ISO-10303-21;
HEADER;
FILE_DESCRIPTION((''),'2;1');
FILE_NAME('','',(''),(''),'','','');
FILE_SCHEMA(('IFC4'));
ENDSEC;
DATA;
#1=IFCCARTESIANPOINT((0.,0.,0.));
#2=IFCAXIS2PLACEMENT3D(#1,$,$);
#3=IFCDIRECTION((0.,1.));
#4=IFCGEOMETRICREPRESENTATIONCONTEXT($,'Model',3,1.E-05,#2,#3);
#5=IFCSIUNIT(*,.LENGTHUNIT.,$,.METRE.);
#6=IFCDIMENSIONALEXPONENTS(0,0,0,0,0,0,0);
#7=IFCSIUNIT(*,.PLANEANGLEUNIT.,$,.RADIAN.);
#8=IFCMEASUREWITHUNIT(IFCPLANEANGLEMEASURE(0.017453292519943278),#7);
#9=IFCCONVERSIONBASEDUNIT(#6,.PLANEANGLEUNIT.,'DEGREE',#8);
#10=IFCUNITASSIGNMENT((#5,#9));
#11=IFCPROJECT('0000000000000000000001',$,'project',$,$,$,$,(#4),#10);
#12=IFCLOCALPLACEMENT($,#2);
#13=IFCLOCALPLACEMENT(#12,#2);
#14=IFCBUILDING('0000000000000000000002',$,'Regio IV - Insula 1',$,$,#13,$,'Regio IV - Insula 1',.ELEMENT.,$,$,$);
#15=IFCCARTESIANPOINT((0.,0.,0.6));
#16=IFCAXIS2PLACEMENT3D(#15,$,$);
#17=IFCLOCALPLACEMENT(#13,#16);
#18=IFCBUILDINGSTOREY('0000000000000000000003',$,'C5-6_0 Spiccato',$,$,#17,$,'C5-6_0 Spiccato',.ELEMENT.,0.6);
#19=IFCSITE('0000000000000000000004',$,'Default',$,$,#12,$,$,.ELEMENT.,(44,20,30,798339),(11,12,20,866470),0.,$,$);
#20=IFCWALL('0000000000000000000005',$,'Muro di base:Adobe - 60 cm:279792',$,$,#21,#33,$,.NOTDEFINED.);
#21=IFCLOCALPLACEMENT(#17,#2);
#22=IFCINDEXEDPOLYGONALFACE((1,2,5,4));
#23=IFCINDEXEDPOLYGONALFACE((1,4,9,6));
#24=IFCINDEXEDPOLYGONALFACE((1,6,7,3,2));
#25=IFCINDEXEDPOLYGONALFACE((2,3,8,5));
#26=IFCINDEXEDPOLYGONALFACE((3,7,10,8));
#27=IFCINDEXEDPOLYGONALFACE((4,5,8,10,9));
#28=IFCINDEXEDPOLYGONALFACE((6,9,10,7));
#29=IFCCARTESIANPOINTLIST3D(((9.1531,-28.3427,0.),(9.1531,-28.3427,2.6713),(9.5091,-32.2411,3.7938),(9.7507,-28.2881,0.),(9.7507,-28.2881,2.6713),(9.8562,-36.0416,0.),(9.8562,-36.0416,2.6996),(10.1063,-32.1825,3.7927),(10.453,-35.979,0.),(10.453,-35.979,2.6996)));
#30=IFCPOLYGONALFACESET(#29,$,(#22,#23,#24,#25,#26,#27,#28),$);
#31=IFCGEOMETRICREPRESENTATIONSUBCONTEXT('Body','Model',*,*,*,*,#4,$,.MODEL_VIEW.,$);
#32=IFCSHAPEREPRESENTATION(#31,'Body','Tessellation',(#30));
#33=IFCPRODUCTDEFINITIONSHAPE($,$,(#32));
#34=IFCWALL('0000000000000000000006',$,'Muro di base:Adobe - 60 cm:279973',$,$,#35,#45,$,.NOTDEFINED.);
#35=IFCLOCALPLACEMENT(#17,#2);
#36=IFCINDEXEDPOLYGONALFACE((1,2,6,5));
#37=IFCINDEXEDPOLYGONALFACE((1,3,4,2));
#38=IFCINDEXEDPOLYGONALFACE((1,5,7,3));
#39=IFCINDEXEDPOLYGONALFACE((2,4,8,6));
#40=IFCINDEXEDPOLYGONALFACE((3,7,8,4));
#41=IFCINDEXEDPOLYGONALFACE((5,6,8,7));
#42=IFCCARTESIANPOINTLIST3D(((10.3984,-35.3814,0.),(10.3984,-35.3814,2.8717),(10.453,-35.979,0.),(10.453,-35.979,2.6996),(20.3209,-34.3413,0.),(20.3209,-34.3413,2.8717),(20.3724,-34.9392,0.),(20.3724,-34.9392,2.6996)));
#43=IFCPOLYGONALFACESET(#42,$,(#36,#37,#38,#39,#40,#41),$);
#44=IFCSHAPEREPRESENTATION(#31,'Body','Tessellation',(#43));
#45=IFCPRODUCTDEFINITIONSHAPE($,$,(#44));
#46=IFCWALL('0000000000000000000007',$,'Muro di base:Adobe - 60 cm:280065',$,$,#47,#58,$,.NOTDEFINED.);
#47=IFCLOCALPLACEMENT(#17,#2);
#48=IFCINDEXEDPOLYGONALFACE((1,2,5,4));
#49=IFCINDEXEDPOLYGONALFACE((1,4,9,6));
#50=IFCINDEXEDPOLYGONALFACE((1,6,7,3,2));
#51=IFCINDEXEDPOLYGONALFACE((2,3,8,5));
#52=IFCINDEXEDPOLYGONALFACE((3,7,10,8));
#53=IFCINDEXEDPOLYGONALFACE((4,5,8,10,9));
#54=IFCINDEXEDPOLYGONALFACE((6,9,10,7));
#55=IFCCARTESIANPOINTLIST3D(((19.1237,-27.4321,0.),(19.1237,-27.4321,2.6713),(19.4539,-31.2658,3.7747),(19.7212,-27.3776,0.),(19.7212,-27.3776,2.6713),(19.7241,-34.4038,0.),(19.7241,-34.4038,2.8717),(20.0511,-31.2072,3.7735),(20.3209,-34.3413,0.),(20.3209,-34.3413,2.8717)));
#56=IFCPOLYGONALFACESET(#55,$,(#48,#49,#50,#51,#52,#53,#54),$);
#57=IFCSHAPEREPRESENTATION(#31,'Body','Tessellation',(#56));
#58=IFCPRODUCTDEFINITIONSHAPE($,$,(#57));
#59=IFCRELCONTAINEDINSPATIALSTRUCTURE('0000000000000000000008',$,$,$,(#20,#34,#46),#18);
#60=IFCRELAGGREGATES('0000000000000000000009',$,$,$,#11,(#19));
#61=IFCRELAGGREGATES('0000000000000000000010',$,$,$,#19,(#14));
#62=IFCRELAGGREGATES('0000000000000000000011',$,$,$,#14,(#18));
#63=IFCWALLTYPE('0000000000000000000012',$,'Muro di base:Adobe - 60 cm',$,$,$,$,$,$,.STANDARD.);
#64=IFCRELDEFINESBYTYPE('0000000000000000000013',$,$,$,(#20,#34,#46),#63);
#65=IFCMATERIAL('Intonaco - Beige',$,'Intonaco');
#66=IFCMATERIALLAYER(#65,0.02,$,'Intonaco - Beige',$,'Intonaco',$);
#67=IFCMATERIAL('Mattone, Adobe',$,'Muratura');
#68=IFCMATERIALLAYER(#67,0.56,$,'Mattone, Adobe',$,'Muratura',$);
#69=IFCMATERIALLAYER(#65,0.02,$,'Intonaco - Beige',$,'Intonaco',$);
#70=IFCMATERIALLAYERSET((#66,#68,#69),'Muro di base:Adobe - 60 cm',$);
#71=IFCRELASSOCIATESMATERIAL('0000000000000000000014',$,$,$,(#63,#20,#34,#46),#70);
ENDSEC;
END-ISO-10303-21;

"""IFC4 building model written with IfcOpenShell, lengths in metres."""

from ifc_helpers import new_model, entity, si_unit, converted_unit, direction, frame, origin, place, context, subcontext, project, spatial, polyline, outline, extrude, clip, bounded_halfspace, material, layer, layer_set, layer_usage, type_object, element, save


model = new_model("IFC4")

# Units and contexts
model_context = context("Model", 3, precision=1e-05, world=origin(), true_north=direction((0.0, 1.0)))
body_context = subcontext(model_context, "Body", "Model", "MODEL_VIEW")
ifc_project = project(units=[si_unit("LENGTHUNIT", "METRE"), converted_unit("PLANEANGLEUNIT", "DEGREE", entity("IfcPlaneAngleMeasure", 0.017453292519943278), si_unit("PLANEANGLEUNIT", "RADIAN"), dimensions=[0, 0, 0, 0, 0, 0, 0])], contexts=[model_context])

# Site, building, storey
site_placement = place(None, origin())
site = spatial("IfcSite", under=ifc_project, at=site_placement, Name="Default", CompositionType="ELEMENT", RefLatitude=(44, 20, 30, 798339), RefLongitude=(11, 12, 20, 866470), RefElevation=0.0)
building_placement = place(site_placement, origin())
building = spatial("IfcBuilding", under=site, at=building_placement, Name="Regio IV - Insula 1", LongName="Regio IV - Insula 1", CompositionType="ELEMENT")
storey_placement = place(building_placement, frame((0.0, 0.0, 0.6)))
storey = spatial("IfcBuildingStorey", under=building, at=storey_placement, Name="C5-6_0 Spiccato", LongName="C5-6_0 Spiccato", CompositionType="ELEMENT", Elevation=0.6)

# Shared definitions
ifc_material_1 = material(Name="Intonaco - Beige", Category="Intonaco")
ifc_layer_1 = layer(ifc_material_1, 0.02, Name="Intonaco - Beige", Category="Intonaco")
ifc_material_2 = material(Name="Mattone, Adobe", Category="Muratura")
ifc_layer_2 = layer(ifc_material_2, 0.56, Name="Mattone, Adobe", Category="Muratura")
ifc_layer_3 = layer(ifc_material_1, 0.02, Name="Intonaco - Beige", Category="Intonaco")
ifc_layer_set_1 = layer_set([ifc_layer_1, ifc_layer_2, ifc_layer_3], Name="Muro di base:Adobe - 60 cm")
wall_type_1 = type_object("IfcWallType", Name="Muro di base:Adobe - 60 cm", PredefinedType="STANDARD", material=ifc_layer_set_1)

# Walls
ifc_layer_usage_1 = layer_usage(ifc_layer_set_1, "AXIS2", "NEGATIVE", 0.3)
wall_1_placement = place(storey_placement, frame((9.4519, -28.3154, 0.0), z_axis=(0.0, 0.0, 1.0), x_axis=(0.090941, -0.995856, 0.0)))
element("IfcWall", 1, at=wall_1_placement, inside=storey, type_object=wall_type_1, material=ifc_layer_usage_1, Name="Muro di base:Adobe - 60 cm:279792", PredefinedType="NOTDEFINED", context=body_context, shape_type="Clipping", body=[
    clip(clip(extrude(outline(polyline([(7.7309, -0.3), (7.7229, 0.3), (7.1229, 0.3), (0.6, 0.3), (0.0, 0.3), (0.0, -0.3), (7.7309, -0.3)])), origin(), (0.0, 0.0, 1.0), 3.7938), bounded_halfspace(frame((0.0, -0.3, 2.6713), z_axis=(-0.275637, 0.0, 0.961262), x_axis=(0.0, -1.0, 0.0)), False, frame((0.0, -0.3, 2.6713)), polyline([(0.0, 0.0), (3.9146, 0.0), (3.9106, 0.6), (0.6, 0.6), (0.0, 0.6), (0.0, 0.0)]))), bounded_halfspace(frame((3.9146, -0.3, 3.7938), z_axis=(0.275613, 0.003688, 0.961262), x_axis=(-0.013379, 0.99991, 0.0)), False, frame((3.9146, -0.3, 3.7938)), polyline([(0.0, 0.0), (3.8163, 0.0), (3.8083, 0.6), (3.2082, 0.6), (-0.004, 0.6), (0.0, 0.0)]))),
])
ifc_layer_usage_2 = layer_usage(ifc_layer_set_1, "AXIS2", "NEGATIVE", 0.3)
wall_2_placement = place(storey_placement, frame((10.4217, -35.6806, 0.0), z_axis=(0.0, 0.0, 1.0), x_axis=(0.99455, 0.104256, 0.0)))
element("IfcWall", 2, at=wall_2_placement, inside=storey, type_object=wall_type_1, material=ifc_layer_usage_2, Name="Muro di base:Adobe - 60 cm:279973", PredefinedType="NOTDEFINED", context=body_context, shape_type="Clipping", body=[
    clip(extrude(outline(polyline([(9.9738, -0.3), (9.9849, 0.3), (9.3848, 0.3), (0.008, 0.3), (0.0, -0.3), (9.9738, -0.3)])), origin(), (0.0, 0.0, 1.0), 2.8717), bounded_halfspace(frame((0.0, -0.3, 2.6996), z_axis=(0.0, -0.275637, 0.961262), x_axis=(1.0, 0.0, 0.0)), False, frame((0.0, -0.3, 2.6996)), polyline([(0.0, 0.0), (9.9738, 0.0), (9.9849, 0.6), (9.3848, 0.6), (0.008, 0.6), (0.0, 0.0)]))),
])
ifc_layer_usage_3 = layer_usage(ifc_layer_set_1, "AXIS2", "NEGATIVE", 0.3)
wall_3_placement = place(storey_placement, frame((20.023, -34.3781, 0.0), z_axis=(0.0, 0.0, 1.0), x_axis=(-0.085801, 0.996312, 0.0)))
element("IfcWall", 3, at=wall_3_placement, inside=storey, type_object=wall_type_1, material=ifc_layer_usage_3, Name="Muro di base:Adobe - 60 cm:280065", PredefinedType="NOTDEFINED", context=body_context, shape_type="Clipping", body=[
    clip(clip(extrude(outline(polyline([(7.0006, -0.3), (6.9975, 0.3), (6.3975, 0.3), (0.0, 0.3), (0.0111, -0.3), (7.0006, -0.3)])), origin(), (0.0, 0.0, 1.0), 3.7747), bounded_halfspace(frame((3.1568, -0.3, 3.7735), z_axis=(0.275634, 0.001422, 0.961262), x_axis=(-0.00516, 0.999987, 0.0)), False, frame((3.1568, -0.3, 3.7735)), polyline([(0.0, 0.0), (3.8438, 0.0), (3.8407, 0.6), (3.2407, 0.6), (-0.0071, 0.6), (0.0, 0.0)]))), bounded_halfspace(frame((0.0111, -0.3, 2.8717), z_axis=(-0.27559, -0.00511, 0.961262), x_axis=(0.018539, -0.999828, 0.0)), False, frame((0.0111, -0.3, 2.8717)), polyline([(0.0, 0.0), (3.1456, 0.0), (3.1385, 0.6), (-0.0111, 0.6), (0.0, 0.0)]))),
])

save(model, "model.ifc")
